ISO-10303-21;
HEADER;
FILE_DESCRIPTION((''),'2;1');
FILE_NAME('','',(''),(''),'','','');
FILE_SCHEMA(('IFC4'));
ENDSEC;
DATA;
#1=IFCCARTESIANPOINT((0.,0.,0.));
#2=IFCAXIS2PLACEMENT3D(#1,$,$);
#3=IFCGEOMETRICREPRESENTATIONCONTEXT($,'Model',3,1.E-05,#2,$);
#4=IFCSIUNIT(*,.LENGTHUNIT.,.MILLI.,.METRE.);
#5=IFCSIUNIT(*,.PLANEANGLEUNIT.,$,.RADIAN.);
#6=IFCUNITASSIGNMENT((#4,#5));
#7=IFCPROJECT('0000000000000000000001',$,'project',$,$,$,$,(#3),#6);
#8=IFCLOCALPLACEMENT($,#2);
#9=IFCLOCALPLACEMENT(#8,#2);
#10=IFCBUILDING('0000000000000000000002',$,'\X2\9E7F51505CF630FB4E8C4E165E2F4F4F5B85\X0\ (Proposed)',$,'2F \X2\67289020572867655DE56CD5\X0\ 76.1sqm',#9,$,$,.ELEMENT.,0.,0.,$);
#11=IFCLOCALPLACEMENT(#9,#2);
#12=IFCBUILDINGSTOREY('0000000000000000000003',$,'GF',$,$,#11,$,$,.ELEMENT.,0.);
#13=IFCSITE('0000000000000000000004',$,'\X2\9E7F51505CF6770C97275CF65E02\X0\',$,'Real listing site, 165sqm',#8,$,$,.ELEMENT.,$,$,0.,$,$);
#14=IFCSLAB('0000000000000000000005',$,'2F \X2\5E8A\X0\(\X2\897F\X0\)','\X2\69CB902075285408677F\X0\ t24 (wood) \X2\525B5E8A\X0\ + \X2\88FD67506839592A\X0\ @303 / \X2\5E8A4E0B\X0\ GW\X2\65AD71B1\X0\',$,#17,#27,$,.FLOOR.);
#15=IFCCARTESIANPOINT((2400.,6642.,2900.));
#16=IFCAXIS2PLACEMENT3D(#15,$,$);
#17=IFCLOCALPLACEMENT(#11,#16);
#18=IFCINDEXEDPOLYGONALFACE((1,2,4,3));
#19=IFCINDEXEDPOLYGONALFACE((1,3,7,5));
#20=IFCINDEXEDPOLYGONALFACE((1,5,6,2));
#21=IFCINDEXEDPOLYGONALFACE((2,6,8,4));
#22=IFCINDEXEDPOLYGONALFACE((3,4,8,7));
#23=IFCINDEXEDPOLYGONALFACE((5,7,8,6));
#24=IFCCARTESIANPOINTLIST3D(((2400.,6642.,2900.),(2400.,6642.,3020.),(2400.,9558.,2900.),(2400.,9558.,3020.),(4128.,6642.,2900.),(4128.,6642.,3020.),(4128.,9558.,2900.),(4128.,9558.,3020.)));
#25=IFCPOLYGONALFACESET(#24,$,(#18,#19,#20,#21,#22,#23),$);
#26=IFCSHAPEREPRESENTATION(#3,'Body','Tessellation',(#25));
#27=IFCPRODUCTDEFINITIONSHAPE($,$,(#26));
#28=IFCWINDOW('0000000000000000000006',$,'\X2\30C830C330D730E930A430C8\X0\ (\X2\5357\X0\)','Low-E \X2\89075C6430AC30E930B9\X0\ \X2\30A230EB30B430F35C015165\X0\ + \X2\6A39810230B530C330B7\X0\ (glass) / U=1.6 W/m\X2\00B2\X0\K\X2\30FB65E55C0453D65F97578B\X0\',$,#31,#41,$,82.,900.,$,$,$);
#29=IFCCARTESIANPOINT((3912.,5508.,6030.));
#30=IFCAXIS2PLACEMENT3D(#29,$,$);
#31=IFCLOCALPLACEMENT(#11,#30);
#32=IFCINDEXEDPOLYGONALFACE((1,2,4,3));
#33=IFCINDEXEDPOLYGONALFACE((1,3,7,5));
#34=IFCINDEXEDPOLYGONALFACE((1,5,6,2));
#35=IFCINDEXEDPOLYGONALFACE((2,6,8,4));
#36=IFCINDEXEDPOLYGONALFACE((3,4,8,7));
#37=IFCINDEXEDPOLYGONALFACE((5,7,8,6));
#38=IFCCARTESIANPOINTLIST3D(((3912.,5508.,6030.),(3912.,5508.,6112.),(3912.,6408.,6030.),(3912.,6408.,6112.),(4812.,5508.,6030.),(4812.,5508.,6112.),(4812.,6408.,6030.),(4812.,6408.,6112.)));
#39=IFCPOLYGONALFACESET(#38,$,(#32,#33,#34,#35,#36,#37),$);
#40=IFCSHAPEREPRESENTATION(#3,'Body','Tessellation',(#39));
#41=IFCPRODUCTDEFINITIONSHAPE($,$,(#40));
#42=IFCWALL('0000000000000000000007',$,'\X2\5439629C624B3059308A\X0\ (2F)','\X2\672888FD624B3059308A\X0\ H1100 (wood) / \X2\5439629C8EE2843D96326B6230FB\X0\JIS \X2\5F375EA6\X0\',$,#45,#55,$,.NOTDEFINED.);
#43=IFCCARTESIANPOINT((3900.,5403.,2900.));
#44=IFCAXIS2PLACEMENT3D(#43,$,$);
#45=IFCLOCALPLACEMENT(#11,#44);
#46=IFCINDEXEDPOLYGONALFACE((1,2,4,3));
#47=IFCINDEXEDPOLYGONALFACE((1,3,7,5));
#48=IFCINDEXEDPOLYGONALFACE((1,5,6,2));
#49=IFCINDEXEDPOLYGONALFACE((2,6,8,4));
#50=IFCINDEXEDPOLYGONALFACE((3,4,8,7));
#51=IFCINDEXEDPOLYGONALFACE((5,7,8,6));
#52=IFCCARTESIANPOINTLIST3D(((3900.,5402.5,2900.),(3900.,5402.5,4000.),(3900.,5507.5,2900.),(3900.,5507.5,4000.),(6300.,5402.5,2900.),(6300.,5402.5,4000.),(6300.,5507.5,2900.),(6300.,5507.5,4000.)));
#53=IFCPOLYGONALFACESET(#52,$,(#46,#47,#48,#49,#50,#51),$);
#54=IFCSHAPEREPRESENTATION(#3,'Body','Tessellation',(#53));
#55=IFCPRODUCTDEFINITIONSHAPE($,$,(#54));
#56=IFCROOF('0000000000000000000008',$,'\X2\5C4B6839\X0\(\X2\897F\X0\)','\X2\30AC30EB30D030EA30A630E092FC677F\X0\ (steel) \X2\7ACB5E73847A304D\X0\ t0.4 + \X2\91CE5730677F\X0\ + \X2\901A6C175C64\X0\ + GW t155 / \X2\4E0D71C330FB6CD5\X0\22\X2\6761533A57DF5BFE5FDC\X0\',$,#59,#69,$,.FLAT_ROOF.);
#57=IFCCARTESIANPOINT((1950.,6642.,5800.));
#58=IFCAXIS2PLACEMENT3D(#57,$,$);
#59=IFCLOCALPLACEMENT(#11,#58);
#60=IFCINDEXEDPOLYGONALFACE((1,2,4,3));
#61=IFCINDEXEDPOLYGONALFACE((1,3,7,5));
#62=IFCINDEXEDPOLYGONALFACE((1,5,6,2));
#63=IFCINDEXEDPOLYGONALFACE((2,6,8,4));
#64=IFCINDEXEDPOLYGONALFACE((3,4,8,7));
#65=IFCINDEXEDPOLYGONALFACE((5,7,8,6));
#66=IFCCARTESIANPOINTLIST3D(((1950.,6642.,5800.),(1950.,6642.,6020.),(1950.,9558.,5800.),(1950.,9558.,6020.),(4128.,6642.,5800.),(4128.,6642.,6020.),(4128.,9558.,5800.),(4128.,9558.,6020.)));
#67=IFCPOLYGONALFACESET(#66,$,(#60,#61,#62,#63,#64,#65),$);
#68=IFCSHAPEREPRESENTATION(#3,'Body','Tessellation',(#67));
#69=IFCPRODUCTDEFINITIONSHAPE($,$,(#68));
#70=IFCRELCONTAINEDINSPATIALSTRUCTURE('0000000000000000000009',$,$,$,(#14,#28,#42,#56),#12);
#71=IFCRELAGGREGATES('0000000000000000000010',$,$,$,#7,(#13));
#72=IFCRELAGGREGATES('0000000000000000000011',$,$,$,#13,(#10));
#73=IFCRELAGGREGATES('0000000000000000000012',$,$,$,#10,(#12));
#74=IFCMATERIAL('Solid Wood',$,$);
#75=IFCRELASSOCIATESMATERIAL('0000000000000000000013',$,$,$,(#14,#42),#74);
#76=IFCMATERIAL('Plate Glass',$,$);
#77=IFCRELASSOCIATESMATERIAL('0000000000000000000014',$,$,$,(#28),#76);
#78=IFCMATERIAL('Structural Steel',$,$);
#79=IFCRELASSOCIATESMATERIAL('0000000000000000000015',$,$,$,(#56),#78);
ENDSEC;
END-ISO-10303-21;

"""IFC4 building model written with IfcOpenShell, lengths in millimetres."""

from ifc_helpers import new_model, si_unit, frame, frame_2d, origin, place, context, project, spatial, rectangle, extrude, material, element, save


model = new_model("IFC4")

# Units and contexts
model_context = context("Model", 3, precision=1e-05, world=origin())
ifc_project = project(units=[si_unit("LENGTHUNIT", "METRE", prefix="MILLI"), si_unit("PLANEANGLEUNIT", "RADIAN")], contexts=[model_context])

# Site, building, storey
site_placement = place(None, origin())
site = spatial("IfcSite", under=ifc_project, at=site_placement, Name="鹿児島県霧島市", ObjectType="Real listing site, 165sqm", CompositionType="ELEMENT", RefElevation=0.0)
building_placement = place(site_placement, origin())
building = spatial("IfcBuilding", under=site, at=building_placement, Name="鹿児島・二世帯住宅 (Proposed)", ObjectType="2F 木造在来工法 76.1sqm", CompositionType="ELEMENT", ElevationOfRefHeight=0.0, ElevationOfTerrain=0.0)
storey_placement = place(building_placement, origin())
storey = spatial("IfcBuildingStorey", under=building, at=storey_placement, Name="GF", CompositionType="ELEMENT", Elevation=0.0)

# Shared definitions
ifc_material_1 = material(Name="Solid Wood")

# Slab
slab_1_placement = place(storey_placement, frame((2400.0, 6642.0, 2900.0)))
element("IfcSlab", 1, at=slab_1_placement, inside=storey, material=ifc_material_1, Name="2F 床(西)", Description="構造用合板 t24 (wood) 剛床 + 製材根太 @303 / 床下 GW断熱", PredefinedType="FLOOR", context=model_context, shape_type="SweptSolid", body=[
    extrude(rectangle(XDim=1728.0, YDim=2916.0, at=frame_2d((864.0, 1458.0))), frame((2400.0, 6642.0, 2900.0)), (0.0, 0.0, 1.0), 120.0),
])

# Window
ifc_material_2 = material(Name="Plate Glass")
window_placement = place(storey_placement, frame((3912.0, 5508.0, 6030.0)))
element("IfcWindow", 2, at=window_placement, inside=storey, material=ifc_material_2, Name="トップライト (南)", Description="Low-E 複層ガラス アルゴン封入 + 樹脂サッシ (glass) / U=1.6 W/m²K・日射取得型", OverallHeight=82.0, OverallWidth=900.0, context=model_context, shape_type="SweptSolid", body=[
    extrude(rectangle(XDim=900.0, YDim=900.0, at=frame_2d((450.0, 450.0))), frame((3912.0, 5508.0, 6030.0)), (0.0, 0.0, 1.0), 82.0),
])

# Wall
wall_placement = place(storey_placement, frame((3900.0, 5403.0, 2900.0)))
element("IfcWall", 3, at=wall_placement, inside=storey, material=ifc_material_1, Name="吹抜手すり (2F)", Description="木製手すり H1100 (wood) / 吹抜転落防止・JIS 強度", PredefinedType="NOTDEFINED", context=model_context, shape_type="SweptSolid", body=[
    extrude(rectangle(XDim=2400.0, YDim=105.0, at=frame_2d((1200.0, 52.0))), frame((3900.0, 5403.0, 2900.0)), (0.0, 0.0, 1.0), 1100.0),
])

# Roof
ifc_material_3 = material(Name="Structural Steel")
for number, where, name in (
    (4, (1950.0, 6642.0, 5800.0), "屋根(西)"),
):
    element("IfcRoof", number, at=place(storey_placement, frame(where)), inside=storey, material=ifc_material_3, Name=name, Description="ガルバリウム鋼板 (steel) 立平葺き t0.4 + 野地板 + 通気層 + GW t155 / 不燃・法22条区域対応", PredefinedType="FLAT_ROOF", context=model_context, shape_type="SweptSolid", body=[
        extrude(rectangle(XDim=2178.0, YDim=2916.0, at=frame_2d((1089.0, 1458.0))), frame((1950.0, 6642.0, 5800.0)), (0.0, 0.0, 1.0), 220.0),
    ])

save(model, "model.ifc")
